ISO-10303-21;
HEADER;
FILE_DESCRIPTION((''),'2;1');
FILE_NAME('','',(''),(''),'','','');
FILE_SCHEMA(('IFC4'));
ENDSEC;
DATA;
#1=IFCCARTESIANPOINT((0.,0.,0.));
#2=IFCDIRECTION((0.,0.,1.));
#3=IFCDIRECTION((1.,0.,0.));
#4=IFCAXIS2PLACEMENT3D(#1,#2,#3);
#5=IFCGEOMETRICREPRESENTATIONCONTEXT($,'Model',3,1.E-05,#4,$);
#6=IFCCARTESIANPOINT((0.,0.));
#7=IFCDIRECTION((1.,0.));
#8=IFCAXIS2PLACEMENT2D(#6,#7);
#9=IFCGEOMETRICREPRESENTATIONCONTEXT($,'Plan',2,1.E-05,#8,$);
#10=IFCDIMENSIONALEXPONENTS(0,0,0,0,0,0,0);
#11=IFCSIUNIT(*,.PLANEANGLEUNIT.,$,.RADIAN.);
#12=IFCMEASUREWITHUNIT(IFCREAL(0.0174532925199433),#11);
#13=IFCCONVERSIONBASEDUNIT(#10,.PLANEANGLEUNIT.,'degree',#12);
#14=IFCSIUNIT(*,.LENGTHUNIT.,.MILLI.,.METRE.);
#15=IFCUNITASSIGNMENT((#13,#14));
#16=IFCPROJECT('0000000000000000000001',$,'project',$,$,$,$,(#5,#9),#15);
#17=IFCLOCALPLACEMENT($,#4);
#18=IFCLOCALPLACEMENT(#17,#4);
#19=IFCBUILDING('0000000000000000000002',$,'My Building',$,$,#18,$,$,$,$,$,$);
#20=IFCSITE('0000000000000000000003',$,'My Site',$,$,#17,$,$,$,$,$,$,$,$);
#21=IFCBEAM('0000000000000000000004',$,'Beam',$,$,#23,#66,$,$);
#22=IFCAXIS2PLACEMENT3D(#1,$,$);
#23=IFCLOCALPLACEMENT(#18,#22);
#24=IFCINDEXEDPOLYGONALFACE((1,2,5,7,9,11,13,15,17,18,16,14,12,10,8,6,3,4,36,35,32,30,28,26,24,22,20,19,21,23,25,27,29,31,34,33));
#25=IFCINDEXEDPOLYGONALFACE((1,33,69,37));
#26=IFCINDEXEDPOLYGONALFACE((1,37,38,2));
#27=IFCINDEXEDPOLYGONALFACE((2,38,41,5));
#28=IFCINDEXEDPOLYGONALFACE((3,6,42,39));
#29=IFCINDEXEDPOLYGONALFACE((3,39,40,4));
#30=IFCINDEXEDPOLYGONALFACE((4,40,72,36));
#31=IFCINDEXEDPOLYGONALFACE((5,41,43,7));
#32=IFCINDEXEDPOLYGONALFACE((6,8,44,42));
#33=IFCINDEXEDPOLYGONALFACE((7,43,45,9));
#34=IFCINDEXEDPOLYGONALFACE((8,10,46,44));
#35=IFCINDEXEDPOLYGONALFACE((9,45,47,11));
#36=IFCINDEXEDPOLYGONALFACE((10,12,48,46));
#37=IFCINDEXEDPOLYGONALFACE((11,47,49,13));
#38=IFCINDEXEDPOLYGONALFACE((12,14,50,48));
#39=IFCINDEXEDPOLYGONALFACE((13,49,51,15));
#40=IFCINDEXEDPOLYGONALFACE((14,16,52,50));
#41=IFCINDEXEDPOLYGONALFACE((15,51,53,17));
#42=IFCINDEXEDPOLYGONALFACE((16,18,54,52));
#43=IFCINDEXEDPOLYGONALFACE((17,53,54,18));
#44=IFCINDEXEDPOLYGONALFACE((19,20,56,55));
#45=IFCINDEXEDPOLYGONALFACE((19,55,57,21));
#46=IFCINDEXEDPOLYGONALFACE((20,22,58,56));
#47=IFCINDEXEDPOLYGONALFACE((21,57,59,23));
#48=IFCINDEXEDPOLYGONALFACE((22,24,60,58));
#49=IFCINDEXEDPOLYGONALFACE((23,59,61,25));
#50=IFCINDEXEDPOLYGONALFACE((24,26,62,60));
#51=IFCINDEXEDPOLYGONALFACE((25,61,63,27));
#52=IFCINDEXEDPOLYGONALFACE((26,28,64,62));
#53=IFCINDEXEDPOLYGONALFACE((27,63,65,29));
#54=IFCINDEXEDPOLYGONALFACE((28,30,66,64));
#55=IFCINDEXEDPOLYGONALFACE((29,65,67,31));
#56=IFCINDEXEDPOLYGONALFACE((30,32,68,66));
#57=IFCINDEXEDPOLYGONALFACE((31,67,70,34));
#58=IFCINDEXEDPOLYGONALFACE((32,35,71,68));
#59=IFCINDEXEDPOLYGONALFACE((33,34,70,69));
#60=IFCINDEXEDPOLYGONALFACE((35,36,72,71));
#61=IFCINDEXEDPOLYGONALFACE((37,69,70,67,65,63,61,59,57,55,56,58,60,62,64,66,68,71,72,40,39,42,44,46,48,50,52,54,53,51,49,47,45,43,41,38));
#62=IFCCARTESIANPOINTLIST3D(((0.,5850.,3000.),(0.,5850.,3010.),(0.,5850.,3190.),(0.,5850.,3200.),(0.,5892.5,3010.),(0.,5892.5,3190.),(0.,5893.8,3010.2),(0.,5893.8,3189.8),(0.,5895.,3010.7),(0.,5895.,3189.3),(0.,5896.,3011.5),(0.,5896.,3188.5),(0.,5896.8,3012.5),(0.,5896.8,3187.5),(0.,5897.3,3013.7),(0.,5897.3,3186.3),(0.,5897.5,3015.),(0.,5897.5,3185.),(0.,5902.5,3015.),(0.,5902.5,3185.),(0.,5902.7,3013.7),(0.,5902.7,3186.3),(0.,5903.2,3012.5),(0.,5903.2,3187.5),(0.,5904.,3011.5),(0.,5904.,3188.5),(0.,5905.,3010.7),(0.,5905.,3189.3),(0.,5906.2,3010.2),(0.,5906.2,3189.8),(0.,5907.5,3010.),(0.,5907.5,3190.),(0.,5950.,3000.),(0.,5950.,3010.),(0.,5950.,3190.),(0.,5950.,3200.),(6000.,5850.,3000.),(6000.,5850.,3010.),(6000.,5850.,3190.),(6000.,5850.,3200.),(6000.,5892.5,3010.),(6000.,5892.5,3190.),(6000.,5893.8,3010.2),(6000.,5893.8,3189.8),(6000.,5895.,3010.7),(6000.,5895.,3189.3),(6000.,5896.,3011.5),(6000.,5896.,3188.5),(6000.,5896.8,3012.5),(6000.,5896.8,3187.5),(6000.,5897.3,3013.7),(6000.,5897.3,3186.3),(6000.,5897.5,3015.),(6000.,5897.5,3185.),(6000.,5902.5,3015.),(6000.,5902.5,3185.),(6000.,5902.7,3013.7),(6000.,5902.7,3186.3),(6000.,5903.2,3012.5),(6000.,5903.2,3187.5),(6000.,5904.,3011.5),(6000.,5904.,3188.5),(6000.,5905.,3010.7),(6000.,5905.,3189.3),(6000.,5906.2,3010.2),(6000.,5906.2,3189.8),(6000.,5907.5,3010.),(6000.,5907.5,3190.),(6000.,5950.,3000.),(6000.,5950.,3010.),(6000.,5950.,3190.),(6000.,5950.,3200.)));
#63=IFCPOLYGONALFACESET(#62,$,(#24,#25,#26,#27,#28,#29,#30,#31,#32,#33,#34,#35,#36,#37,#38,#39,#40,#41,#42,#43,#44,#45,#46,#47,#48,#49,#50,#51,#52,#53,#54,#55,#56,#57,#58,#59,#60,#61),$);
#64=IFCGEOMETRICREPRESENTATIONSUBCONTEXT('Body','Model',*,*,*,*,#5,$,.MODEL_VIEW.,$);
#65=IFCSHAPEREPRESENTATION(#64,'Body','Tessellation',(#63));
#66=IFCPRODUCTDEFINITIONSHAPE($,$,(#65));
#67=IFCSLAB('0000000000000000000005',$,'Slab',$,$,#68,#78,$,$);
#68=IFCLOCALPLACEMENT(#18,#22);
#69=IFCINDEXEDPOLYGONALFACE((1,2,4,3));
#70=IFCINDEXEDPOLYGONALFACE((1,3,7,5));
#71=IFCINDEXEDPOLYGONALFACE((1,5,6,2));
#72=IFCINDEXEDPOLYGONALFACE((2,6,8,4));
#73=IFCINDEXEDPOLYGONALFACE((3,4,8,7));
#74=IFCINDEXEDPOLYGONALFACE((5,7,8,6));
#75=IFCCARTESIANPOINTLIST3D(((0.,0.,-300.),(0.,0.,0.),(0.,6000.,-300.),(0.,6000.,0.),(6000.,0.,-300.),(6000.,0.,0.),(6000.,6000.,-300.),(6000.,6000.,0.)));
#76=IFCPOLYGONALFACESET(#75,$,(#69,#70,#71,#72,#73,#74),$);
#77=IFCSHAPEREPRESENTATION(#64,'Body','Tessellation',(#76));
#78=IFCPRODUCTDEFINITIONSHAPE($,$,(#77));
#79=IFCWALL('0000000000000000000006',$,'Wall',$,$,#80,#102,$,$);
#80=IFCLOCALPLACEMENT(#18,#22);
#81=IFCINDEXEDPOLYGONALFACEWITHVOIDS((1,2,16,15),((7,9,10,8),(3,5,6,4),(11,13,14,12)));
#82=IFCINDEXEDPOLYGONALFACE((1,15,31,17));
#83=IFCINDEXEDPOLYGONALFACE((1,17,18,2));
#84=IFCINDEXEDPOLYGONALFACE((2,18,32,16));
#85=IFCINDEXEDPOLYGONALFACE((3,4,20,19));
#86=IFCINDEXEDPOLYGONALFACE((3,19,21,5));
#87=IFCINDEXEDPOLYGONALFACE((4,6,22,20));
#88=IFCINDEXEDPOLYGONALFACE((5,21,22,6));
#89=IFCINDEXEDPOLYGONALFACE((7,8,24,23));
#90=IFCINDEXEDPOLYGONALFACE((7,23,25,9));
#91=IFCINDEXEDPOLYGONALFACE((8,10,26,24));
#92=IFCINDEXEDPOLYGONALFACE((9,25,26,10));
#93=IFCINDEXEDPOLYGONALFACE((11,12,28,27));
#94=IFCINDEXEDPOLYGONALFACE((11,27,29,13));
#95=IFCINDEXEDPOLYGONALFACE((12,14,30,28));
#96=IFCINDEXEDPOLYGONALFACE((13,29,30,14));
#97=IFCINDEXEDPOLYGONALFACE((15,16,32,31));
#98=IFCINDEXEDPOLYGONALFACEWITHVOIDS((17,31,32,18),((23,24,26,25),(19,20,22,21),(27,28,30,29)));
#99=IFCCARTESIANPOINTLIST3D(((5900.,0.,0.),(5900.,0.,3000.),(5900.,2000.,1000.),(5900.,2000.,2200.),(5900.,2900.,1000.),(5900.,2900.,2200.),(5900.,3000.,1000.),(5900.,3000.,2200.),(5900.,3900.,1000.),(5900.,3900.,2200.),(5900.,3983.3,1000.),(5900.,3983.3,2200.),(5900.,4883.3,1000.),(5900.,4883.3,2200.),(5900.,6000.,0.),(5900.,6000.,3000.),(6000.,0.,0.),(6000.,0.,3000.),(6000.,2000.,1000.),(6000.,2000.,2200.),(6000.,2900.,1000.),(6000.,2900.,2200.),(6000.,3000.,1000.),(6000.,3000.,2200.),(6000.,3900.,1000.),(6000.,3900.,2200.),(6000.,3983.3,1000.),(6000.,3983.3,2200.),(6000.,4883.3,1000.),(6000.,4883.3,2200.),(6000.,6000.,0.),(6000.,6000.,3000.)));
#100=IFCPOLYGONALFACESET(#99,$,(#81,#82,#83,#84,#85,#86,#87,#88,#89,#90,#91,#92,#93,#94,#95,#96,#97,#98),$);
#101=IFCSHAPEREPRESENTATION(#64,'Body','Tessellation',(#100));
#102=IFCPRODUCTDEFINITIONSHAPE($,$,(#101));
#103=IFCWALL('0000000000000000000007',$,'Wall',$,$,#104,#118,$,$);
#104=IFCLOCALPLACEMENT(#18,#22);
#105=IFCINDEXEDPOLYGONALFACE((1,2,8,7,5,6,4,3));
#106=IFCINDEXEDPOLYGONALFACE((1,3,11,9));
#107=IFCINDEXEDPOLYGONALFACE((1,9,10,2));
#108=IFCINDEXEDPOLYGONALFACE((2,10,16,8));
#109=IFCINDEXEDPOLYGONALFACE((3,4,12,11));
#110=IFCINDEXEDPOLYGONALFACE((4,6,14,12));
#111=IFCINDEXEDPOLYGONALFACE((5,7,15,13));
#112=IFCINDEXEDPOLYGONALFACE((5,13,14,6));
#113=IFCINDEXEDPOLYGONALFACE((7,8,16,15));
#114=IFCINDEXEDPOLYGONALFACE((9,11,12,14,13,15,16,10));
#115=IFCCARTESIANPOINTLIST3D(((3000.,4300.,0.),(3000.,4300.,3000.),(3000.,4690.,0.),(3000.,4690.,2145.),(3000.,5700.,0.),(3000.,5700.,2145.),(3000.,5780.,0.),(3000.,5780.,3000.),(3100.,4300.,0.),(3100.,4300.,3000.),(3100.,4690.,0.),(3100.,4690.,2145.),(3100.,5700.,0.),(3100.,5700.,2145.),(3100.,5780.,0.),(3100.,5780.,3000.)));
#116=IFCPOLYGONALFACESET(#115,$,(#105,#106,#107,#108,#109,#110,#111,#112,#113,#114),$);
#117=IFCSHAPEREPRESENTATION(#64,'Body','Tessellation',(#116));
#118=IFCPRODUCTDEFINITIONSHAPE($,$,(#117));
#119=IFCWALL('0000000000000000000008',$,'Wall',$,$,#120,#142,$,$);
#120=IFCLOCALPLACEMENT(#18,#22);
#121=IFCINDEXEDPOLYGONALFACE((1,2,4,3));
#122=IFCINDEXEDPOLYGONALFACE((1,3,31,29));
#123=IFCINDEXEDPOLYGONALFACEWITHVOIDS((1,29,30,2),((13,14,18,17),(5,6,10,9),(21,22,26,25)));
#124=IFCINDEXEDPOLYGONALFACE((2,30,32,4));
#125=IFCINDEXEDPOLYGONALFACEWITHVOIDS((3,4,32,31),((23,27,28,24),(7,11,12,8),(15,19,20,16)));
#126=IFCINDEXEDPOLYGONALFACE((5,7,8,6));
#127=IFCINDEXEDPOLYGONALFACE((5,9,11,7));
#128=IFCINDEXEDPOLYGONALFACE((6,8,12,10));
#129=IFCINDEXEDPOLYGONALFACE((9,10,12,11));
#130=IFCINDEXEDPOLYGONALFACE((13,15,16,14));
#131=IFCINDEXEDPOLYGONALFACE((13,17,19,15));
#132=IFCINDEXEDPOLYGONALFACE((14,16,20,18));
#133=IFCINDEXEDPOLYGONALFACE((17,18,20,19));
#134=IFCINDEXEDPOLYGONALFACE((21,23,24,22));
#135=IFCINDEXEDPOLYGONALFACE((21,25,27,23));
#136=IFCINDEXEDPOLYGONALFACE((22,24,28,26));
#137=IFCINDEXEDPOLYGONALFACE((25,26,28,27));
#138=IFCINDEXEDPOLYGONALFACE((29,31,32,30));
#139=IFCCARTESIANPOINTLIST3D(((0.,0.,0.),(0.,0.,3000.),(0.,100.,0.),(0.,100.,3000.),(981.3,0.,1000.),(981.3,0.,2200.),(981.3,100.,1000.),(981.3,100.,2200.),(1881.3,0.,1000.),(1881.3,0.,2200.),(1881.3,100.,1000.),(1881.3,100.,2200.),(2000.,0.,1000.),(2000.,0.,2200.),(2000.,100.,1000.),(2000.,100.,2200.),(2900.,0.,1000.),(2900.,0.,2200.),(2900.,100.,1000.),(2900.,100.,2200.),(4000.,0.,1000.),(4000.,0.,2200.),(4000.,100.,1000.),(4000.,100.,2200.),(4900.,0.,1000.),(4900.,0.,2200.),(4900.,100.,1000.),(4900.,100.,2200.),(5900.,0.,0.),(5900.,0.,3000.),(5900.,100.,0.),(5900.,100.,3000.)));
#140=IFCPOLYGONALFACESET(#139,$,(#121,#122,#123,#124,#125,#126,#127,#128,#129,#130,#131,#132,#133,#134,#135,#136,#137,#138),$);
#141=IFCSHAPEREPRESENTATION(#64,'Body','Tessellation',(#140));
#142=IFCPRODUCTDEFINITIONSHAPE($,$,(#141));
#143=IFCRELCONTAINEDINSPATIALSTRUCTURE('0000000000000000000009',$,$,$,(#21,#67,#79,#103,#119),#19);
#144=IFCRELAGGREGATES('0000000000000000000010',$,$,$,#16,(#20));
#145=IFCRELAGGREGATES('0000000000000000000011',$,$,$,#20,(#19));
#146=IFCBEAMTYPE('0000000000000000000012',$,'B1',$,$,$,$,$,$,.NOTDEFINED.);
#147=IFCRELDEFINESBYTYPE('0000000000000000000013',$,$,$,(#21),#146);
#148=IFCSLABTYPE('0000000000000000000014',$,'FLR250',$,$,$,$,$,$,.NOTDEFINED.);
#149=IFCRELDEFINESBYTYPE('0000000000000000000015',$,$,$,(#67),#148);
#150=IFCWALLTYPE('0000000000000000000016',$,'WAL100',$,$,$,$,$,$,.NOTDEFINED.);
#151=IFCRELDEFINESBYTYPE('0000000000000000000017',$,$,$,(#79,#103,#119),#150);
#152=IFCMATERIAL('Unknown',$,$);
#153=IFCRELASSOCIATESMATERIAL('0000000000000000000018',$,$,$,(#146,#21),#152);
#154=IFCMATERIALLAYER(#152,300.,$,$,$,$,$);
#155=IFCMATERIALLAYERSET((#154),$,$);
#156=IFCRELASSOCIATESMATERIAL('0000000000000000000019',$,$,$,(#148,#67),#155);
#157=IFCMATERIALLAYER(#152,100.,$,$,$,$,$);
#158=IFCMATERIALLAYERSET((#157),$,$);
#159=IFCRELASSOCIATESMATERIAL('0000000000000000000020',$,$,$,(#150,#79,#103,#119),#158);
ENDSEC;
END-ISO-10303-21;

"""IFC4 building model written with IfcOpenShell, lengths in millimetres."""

from ifc_helpers import new_model, entity, si_unit, converted_unit, frame, origin_with_axes, origin_2d_with_axis, place, context, subcontext, project, spatial, line, indexed_curve, i_section, outline, extrude, source, transform, mapped, material, layer, layer_set, layer_usage, material_profile, profile_set, profile_usage, type_object, element, save


model = new_model("IFC4")

# Units and contexts
model_context = context("Model", 3, precision=1e-05, world=origin_with_axes())
plan_context = context("Plan", 2, precision=1e-05, world=origin_2d_with_axis())
body_context = subcontext(model_context, "Body", "Model", "MODEL_VIEW")
ifc_project = project(units=[converted_unit("PLANEANGLEUNIT", "degree", entity("IfcReal", 0.0174532925199433), si_unit("PLANEANGLEUNIT", "RADIAN"), dimensions=[0, 0, 0, 0, 0, 0, 0]), si_unit("LENGTHUNIT", "METRE", prefix="MILLI")], contexts=[model_context, plan_context])

# Site, building
site_placement = place(None, origin_with_axes())
site = spatial("IfcSite", under=ifc_project, at=site_placement, Name="My Site")
building_placement = place(site_placement, origin_with_axes())
building = spatial("IfcBuilding", under=site, at=building_placement, Name="My Building")

# Shared definitions
ifc_material_1 = material(Name="Unknown")

# Beam
ifc_material_profile_1 = material_profile(ifc_material_1, i_section(OverallWidth=100.0, OverallDepth=200.0, WebThickness=5.0, FlangeThickness=10.0, FilletRadius=5.0))
ifc_profile_set_1 = profile_set([ifc_material_profile_1])
beam_type = type_object("IfcBeamType", Name="B1", PredefinedType="NOTDEFINED", material=ifc_profile_set_1)
ifc_profile_usage_1 = profile_usage(ifc_profile_set_1, cardinal=5)
beam_1_placement = place(building_placement, frame((0.0, 5900.0, 3100.0), z_axis=(1.0, 0.0, 0.0), x_axis=(0.0, 1.0, 0.0)))
element("IfcBeam", 1, at=beam_1_placement, inside=building, type_object=beam_type, material=ifc_profile_usage_1, Name="Beam", context=body_context, shape_type="SweptSolid", body=[
    extrude(i_section(OverallWidth=100.0, OverallDepth=200.0, WebThickness=5.0, FlangeThickness=10.0, FilletRadius=5.0), origin_with_axes(), (0.0, 0.0, 1.0), 6000.0),
])

# Slab
ifc_layer_1 = layer(ifc_material_1, 300.0)
ifc_layer_set_1 = layer_set([ifc_layer_1])
ifc_layer_usage_1 = layer_usage(ifc_layer_set_1, "AXIS3", "POSITIVE", 0.0)
slab_type = type_object("IfcSlabType", Name="FLR250", PredefinedType="NOTDEFINED", material=ifc_layer_set_1)
slab_placement = place(building_placement, frame((0.0, 0.0, -300.0), z_axis=(0.0, 0.0, 1.0), x_axis=(1.0, 0.0, 0.0)))
element("IfcSlab", 2, at=slab_placement, inside=building, type_object=slab_type, material=ifc_layer_usage_1, Name="Slab", context=body_context, shape_type="SweptSolid", body=[
    extrude(outline(indexed_curve([(0.0, 0.0), (6000.0, 0.0), (6000.0, 6000.0), (0.0, 6000.0)], segments=[line(4, 1), line(1, 2), line(2, 3), line(3, 4)], self_intersect=False)), None, (0.0, 0.0, 1.0), 300.0),
])

# Wall, openings
ifc_layer_2 = layer(ifc_material_1, 100.0)
ifc_layer_set_2 = layer_set([ifc_layer_2])
ifc_layer_usage_2 = layer_usage(ifc_layer_set_2, "AXIS2", "POSITIVE", 0.0)
wall_type_1 = type_object("IfcWallType", Name="WAL100", PredefinedType="NOTDEFINED", material=ifc_layer_set_2)
wall_1_placement = place(building_placement, frame((6000.0, 0.0, 0.0), z_axis=(0.0, 0.0, 1.0), x_axis=(0.0, 1.0, 0.0)))
wall_1 = element("IfcWall", 3, at=wall_1_placement, inside=building, type_object=wall_type_1, material=ifc_layer_usage_2, Name="Wall", context=body_context, shape_type="SweptSolid", body=[
    extrude(outline(indexed_curve([(0.0, 0.0), (0.0, 100.0), (6000.0, 100.0), (6000.0, 0.0), (0.0, 0.0)], self_intersect=False)), origin_with_axes(), (0.0, 0.0, 1.0), 3000.0),
])
shared_shape_1 = source(origin_with_axes(), body_context, "Body", "SweptSolid", [
    extrude(outline(indexed_curve([(0.0, 0.0), (900.0, 0.0), (900.0, 1200.0), (0.0, 1200.0)], segments=[line(1, 2, 3, 4, 1)])), frame((0.0, -600.0, 0.0), z_axis=(0.0, -1.0, 0.0), x_axis=(1.0, 0.0, 0.0)), (0.0, 0.0, -1.0), 1200.0),
])
opening_1_placement = place(wall_1_placement, frame((3000.0, 0.0, 1000.0), z_axis=(0.0, 0.0, 1.0), x_axis=(1.0, 0.0, 0.0)))
element("IfcOpeningElement", 4, at=opening_1_placement, cuts=wall_1, PredefinedType="OPENING", context=body_context, shape_type="MappedRepresentation", body=[
    mapped(shared_shape_1, transform((0.0, 0.0, 0.0), x_axis=(1.0, 0.0, 0.0), y_axis=(0.0, 1.0, 0.0), z_axis=(0.0, 0.0, 1.0), scale=1.0)),
])
opening_2_placement = place(wall_1_placement, frame((3983.3, 0.0, 1000.0), z_axis=(0.0, 0.0, 1.0), x_axis=(1.0, 0.0, 0.0)))
element("IfcOpeningElement", 5, at=opening_2_placement, cuts=wall_1, PredefinedType="OPENING", context=body_context, shape_type="MappedRepresentation", body=[
    mapped(shared_shape_1, transform((0.0, 0.0, 0.0), x_axis=(1.0, 0.0, 0.0), y_axis=(0.0, 1.0, 0.0), z_axis=(0.0, 0.0, 1.0), scale=1.0)),
])
opening_3_placement = place(wall_1_placement, frame((2000.0, 0.0, 1000.0), z_axis=(0.0, 0.0, 1.0), x_axis=(1.0, 0.0, 0.0)))
element("IfcOpeningElement", 6, at=opening_3_placement, cuts=wall_1, PredefinedType="OPENING", context=body_context, shape_type="MappedRepresentation", body=[
    mapped(shared_shape_1, transform((0.0, 0.0, 0.0), x_axis=(1.0, 0.0, 0.0), y_axis=(0.0, 1.0, 0.0), z_axis=(0.0, 0.0, 1.0), scale=1.0)),
])

# Wall, opening
ifc_layer_usage_3 = layer_usage(ifc_layer_set_2, "AXIS2", "POSITIVE", 0.0)
wall_2_placement = place(building_placement, frame((3000.0, 5780.0, 0.0), z_axis=(0.0, 0.0, 1.0), x_axis=(0.0, -1.0, 0.0)))
wall_2 = element("IfcWall", 7, at=wall_2_placement, inside=building, type_object=wall_type_1, material=ifc_layer_usage_3, Name="Wall", context=body_context, shape_type="SweptSolid", body=[
    extrude(outline(indexed_curve([(0.0, 0.0), (0.0, 100.0), (1480.0, 100.0), (1480.0, 0.0), (0.0, 0.0)], self_intersect=False)), origin_with_axes(), (0.0, 0.0, 1.0), 3000.0),
])
shared_shape_2 = source(origin_with_axes(), body_context, "Body", "SweptSolid", [
    extrude(outline(indexed_curve([(0.0, 0.0), (1010.0, 0.0), (1010.0, 2145.0), (0.0, 2145.0)], segments=[line(1, 2, 3, 4, 1)])), frame((0.0, -600.0, 0.0), z_axis=(0.0, -1.0, 0.0), x_axis=(1.0, 0.0, 0.0)), (0.0, 0.0, -1.0), 1200.0),
])
opening_4_placement = place(wall_2_placement, frame((80.0, 0.0, 0.0), z_axis=(0.0, 0.0, 1.0), x_axis=(1.0, 0.0, 0.0)))
element("IfcOpeningElement", 8, at=opening_4_placement, cuts=wall_2, PredefinedType="OPENING", context=body_context, shape_type="MappedRepresentation", body=[
    mapped(shared_shape_2, transform((0.0, 0.0, 0.0), x_axis=(1.0, 0.0, 0.0), y_axis=(0.0, 1.0, 0.0), z_axis=(0.0, 0.0, 1.0), scale=1.0)),
])

# Wall, openings
ifc_layer_usage_4 = layer_usage(ifc_layer_set_2, "AXIS2", "POSITIVE", 0.0)
wall_3_placement = place(building_placement, frame((0.0, 0.0, 0.0), z_axis=(0.0, 0.0, 1.0), x_axis=(1.0, 0.0, 0.0)))
wall_3 = element("IfcWall", 9, at=wall_3_placement, inside=building, type_object=wall_type_1, material=ifc_layer_usage_4, Name="Wall", context=body_context, shape_type="SweptSolid", body=[
    extrude(outline(indexed_curve([(0.0, 0.0), (0.0, 100.0), (5900.0, 100.0), (5900.0, 0.0), (0.0, 0.0)], self_intersect=False)), origin_with_axes(), (0.0, 0.0, 1.0), 3000.0),
])
opening_5_placement = place(wall_3_placement, frame((981.3, 0.0, 1000.0), z_axis=(0.0, 0.0, 1.0), x_axis=(1.0, 0.0, 0.0)))
element("IfcOpeningElement", 10, at=opening_5_placement, cuts=wall_3, PredefinedType="OPENING", context=body_context, shape_type="MappedRepresentation", body=[
    mapped(shared_shape_1, transform((0.0, 0.0, 0.0), x_axis=(1.0, 0.0, 0.0), y_axis=(0.0, 1.0, 0.0), z_axis=(0.0, 0.0, 1.0), scale=1.0)),
])
opening_6_placement = place(wall_3_placement, frame((4000.0, 0.0, 1000.0), z_axis=(0.0, 0.0, 1.0), x_axis=(1.0, 0.0, 0.0)))
element("IfcOpeningElement", 11, at=opening_6_placement, cuts=wall_3, PredefinedType="OPENING", context=body_context, shape_type="MappedRepresentation", body=[
    mapped(shared_shape_1, transform((0.0, 0.0, 0.0), x_axis=(1.0, 0.0, 0.0), y_axis=(0.0, 1.0, 0.0), z_axis=(0.0, 0.0, 1.0), scale=1.0)),
])
opening_7_placement = place(wall_3_placement, frame((2000.0, 0.0, 1000.0), z_axis=(0.0, 0.0, 1.0), x_axis=(1.0, 0.0, 0.0)))
element("IfcOpeningElement", 12, at=opening_7_placement, cuts=wall_3, PredefinedType="OPENING", context=body_context, shape_type="MappedRepresentation", body=[
    mapped(shared_shape_1, transform((0.0, 0.0, 0.0), x_axis=(1.0, 0.0, 0.0), y_axis=(0.0, 1.0, 0.0), z_axis=(0.0, 0.0, 1.0), scale=1.0)),
])

save(model, "model.ifc")
